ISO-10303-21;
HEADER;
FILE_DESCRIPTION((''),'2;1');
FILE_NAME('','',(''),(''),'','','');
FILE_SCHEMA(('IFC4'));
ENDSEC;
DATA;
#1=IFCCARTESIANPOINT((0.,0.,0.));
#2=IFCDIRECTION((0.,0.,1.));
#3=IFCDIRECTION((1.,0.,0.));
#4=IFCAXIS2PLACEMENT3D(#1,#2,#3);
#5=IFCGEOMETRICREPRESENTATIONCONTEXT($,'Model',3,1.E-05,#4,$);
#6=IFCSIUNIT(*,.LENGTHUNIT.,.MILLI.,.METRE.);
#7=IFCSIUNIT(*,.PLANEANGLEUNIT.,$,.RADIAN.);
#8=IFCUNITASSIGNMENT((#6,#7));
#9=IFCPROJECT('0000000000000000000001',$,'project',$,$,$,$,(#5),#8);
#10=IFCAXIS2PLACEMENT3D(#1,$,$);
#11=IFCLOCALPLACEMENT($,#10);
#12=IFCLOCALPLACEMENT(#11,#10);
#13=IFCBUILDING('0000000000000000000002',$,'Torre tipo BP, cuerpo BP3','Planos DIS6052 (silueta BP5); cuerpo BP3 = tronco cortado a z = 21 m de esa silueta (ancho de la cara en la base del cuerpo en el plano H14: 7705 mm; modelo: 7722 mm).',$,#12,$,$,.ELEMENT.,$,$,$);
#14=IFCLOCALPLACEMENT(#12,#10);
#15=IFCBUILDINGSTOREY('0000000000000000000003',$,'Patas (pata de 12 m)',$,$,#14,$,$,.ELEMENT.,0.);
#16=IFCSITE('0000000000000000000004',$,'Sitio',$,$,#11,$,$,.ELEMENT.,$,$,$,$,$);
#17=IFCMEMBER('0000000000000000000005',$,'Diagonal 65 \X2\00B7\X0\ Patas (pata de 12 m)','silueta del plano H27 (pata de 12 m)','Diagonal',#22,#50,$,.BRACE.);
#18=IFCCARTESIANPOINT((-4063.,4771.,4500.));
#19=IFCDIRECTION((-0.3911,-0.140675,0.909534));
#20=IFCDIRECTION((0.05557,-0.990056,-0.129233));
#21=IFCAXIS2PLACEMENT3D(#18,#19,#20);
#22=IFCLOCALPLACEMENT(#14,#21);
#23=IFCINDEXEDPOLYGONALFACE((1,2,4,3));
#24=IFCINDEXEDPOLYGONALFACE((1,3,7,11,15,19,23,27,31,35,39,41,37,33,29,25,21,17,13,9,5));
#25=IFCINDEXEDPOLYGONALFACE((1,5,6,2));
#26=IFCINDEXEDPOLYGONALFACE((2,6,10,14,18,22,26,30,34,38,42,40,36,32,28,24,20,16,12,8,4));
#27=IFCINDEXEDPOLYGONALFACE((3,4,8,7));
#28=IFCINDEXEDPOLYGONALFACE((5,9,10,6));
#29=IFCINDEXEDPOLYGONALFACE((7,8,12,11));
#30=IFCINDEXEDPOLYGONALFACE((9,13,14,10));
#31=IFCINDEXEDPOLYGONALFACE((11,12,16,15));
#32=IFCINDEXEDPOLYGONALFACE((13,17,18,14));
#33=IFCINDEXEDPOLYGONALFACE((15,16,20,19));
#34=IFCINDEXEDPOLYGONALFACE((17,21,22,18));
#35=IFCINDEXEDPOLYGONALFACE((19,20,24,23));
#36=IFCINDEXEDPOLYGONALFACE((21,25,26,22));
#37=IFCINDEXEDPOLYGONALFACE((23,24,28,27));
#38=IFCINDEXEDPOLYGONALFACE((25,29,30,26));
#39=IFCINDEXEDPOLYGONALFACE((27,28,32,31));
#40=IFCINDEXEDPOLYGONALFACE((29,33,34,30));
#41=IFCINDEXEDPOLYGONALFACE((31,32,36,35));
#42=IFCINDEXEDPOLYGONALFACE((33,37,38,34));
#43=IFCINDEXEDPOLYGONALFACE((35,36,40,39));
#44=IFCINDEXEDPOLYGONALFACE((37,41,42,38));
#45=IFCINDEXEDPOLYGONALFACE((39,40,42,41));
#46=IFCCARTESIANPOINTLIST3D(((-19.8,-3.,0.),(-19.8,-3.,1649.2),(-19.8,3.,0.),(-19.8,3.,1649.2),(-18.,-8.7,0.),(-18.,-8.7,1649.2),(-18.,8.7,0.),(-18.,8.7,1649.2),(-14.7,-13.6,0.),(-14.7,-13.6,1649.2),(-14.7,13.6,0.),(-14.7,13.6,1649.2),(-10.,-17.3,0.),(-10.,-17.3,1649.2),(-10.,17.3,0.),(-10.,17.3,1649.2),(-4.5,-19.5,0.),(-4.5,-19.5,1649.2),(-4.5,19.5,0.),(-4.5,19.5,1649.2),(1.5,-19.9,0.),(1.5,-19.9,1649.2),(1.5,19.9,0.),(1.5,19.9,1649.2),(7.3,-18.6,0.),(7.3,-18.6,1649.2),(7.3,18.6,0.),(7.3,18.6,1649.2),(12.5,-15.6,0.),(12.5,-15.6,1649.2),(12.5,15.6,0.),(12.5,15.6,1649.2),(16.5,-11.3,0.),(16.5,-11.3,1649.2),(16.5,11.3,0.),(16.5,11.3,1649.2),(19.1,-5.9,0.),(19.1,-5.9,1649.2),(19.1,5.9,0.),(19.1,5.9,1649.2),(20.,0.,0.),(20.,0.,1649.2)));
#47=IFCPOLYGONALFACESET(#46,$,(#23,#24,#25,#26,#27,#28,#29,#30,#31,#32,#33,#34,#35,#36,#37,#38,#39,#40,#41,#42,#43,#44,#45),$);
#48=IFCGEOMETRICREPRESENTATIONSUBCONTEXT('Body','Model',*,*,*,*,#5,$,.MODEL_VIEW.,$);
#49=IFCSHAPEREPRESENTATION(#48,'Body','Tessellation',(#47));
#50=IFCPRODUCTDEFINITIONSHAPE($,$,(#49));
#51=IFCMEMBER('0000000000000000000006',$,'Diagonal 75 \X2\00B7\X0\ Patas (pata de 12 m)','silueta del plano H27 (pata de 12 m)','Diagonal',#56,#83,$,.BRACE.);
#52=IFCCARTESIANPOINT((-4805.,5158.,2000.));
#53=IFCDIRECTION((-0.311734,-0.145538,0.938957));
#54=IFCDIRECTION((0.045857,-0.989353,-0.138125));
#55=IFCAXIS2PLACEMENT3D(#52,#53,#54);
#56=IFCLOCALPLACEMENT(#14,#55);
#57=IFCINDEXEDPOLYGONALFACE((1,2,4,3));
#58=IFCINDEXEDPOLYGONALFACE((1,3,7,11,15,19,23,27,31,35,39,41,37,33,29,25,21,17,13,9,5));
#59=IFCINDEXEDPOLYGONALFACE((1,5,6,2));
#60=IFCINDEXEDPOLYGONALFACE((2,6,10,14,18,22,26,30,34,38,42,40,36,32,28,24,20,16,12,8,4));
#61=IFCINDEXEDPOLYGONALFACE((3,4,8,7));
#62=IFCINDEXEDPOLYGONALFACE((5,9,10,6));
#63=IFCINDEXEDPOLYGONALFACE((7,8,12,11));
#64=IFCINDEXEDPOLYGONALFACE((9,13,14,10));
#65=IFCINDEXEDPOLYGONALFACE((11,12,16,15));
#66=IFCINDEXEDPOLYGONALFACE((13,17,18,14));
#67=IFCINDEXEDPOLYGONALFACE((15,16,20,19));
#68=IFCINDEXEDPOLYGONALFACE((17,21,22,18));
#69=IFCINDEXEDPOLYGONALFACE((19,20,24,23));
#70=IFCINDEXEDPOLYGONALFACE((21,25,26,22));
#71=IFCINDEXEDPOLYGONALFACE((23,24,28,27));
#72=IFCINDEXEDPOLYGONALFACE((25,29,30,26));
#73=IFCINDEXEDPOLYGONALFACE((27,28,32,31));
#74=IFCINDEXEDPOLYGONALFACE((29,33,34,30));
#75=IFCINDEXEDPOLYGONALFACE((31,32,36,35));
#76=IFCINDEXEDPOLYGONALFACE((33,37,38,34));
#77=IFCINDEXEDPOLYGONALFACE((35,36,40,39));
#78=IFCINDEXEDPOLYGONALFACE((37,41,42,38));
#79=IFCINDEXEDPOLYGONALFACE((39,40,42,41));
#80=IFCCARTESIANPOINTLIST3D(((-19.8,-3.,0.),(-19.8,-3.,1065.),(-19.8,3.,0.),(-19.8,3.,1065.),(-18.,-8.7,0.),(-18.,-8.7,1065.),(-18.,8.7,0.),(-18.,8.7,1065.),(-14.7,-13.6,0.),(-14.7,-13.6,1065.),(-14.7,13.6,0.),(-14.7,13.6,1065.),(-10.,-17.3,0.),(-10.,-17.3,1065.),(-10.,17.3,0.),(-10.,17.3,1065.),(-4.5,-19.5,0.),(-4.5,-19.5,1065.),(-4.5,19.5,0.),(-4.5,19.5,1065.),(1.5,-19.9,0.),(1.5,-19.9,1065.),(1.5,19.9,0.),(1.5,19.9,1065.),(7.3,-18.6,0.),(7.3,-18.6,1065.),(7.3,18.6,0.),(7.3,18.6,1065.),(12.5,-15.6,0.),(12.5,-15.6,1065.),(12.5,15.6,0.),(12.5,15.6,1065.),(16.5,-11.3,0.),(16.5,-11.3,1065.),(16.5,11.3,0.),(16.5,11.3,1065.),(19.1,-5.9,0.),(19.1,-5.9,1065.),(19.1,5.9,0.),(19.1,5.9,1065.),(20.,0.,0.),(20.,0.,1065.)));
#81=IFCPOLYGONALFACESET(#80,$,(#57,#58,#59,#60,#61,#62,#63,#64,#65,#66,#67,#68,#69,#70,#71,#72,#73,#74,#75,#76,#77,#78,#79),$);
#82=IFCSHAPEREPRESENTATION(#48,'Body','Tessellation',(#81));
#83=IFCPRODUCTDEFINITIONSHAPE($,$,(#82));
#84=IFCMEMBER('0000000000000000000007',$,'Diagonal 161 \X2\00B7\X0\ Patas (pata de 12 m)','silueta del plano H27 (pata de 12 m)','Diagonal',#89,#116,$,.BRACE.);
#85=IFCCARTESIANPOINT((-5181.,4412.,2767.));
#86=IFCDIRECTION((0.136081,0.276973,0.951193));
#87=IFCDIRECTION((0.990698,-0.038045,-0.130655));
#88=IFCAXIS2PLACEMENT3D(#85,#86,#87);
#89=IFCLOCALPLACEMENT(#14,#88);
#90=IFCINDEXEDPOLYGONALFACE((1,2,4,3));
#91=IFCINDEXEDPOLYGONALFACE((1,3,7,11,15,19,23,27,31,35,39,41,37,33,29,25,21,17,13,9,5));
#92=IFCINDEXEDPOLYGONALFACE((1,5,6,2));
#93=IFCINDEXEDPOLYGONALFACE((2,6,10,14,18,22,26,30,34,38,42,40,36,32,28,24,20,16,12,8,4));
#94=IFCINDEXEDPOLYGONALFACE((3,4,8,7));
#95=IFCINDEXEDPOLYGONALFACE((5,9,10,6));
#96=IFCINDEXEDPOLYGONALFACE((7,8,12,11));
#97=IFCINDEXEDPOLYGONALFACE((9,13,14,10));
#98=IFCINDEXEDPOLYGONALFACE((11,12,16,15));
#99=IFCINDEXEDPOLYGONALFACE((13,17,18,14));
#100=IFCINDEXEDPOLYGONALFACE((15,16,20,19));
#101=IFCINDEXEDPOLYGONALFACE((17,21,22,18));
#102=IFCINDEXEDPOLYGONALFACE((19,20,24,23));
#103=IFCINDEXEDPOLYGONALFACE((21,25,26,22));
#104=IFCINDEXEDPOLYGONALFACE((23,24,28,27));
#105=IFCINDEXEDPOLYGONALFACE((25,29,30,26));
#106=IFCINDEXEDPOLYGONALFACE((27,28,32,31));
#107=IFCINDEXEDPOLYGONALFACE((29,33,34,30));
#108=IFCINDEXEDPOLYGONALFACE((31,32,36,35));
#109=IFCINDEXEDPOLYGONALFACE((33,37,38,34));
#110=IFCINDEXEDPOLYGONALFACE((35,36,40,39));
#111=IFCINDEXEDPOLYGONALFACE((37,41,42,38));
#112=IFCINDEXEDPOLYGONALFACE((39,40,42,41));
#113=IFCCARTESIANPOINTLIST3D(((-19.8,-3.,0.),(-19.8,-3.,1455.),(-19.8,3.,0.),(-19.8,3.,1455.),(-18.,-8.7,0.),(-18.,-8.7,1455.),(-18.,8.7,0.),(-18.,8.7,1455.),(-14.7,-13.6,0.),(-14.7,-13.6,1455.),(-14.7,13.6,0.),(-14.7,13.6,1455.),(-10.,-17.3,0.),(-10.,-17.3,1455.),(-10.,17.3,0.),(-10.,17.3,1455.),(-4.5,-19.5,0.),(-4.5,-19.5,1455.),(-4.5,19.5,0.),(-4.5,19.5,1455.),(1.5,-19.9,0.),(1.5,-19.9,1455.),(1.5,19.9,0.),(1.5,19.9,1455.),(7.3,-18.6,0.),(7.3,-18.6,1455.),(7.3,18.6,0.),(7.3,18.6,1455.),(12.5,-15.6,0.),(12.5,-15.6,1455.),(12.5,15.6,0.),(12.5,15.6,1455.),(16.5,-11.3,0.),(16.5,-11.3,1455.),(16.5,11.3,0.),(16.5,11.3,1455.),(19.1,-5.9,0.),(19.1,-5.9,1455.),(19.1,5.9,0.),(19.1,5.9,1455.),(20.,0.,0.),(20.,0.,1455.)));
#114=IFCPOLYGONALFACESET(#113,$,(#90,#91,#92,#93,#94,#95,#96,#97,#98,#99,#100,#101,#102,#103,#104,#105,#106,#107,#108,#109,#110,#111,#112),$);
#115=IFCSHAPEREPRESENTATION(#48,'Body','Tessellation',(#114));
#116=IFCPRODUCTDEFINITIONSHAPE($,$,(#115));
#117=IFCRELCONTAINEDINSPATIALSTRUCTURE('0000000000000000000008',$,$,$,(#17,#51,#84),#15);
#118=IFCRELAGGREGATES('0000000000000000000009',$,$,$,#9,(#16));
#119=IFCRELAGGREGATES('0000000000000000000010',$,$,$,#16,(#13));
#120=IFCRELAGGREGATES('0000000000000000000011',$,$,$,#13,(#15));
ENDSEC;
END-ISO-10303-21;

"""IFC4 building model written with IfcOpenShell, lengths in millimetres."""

from ifc_helpers import new_model, si_unit, frame, origin, origin_with_axes, place, context, subcontext, project, spatial, circle, extrude, element, save


model = new_model("IFC4")

# Units and contexts
model_context = context("Model", 3, precision=1e-05, world=origin_with_axes())
body_context = subcontext(model_context, "Body", "Model", "MODEL_VIEW")
ifc_project = project(units=[si_unit("LENGTHUNIT", "METRE", prefix="MILLI"), si_unit("PLANEANGLEUNIT", "RADIAN")], contexts=[model_context])

# Site, building, storey
site_placement = place(None, origin())
site = spatial("IfcSite", under=ifc_project, at=site_placement, Name="Sitio", CompositionType="ELEMENT")
building_placement = place(site_placement, origin())
building = spatial("IfcBuilding", under=site, at=building_placement, Name="Torre tipo BP, cuerpo BP3", Description="Planos DIS6052 (silueta BP5); cuerpo BP3 = tronco cortado a z = 21 m de esa silueta (ancho de la cara en la base del cuerpo en el plano H14: 7705 mm; modelo: 7722 mm).", CompositionType="ELEMENT")
storey_placement = place(building_placement, origin())
storey = spatial("IfcBuildingStorey", under=building, at=storey_placement, Name="Patas (pata de 12 m)", CompositionType="ELEMENT", Elevation=0.0)

# Members
member_1_placement = place(storey_placement, frame((-4063.0, 4771.0, 4500.0), z_axis=(-0.3911, -0.140675, 0.909534), x_axis=(0.05557, -0.990056, -0.129233)))
element("IfcMember", 1, at=member_1_placement, inside=storey, Name="Diagonal 65 · Patas (pata de 12 m)", Description="silueta del plano H27 (pata de 12 m)", ObjectType="Diagonal", PredefinedType="BRACE", context=body_context, shape_type="SweptSolid", body=[
    extrude(circle(Radius=20.0), None, (0.0, 0.0, 1.0), 1649.2),
])
member_2_placement = place(storey_placement, frame((-4805.0, 5158.0, 2000.0), z_axis=(-0.311734, -0.145538, 0.938957), x_axis=(0.045857, -0.989353, -0.138125)))
element("IfcMember", 2, at=member_2_placement, inside=storey, Name="Diagonal 75 · Patas (pata de 12 m)", Description="silueta del plano H27 (pata de 12 m)", ObjectType="Diagonal", PredefinedType="BRACE", context=body_context, shape_type="SweptSolid", body=[
    extrude(circle(Radius=20.0), None, (0.0, 0.0, 1.0), 1065.0),
])
member_3_placement = place(storey_placement, frame((-5181.0, 4412.0, 2767.0), z_axis=(0.136081, 0.276973, 0.951193), x_axis=(0.990698, -0.038045, -0.130655)))
element("IfcMember", 3, at=member_3_placement, inside=storey, Name="Diagonal 161 · Patas (pata de 12 m)", Description="silueta del plano H27 (pata de 12 m)", ObjectType="Diagonal", PredefinedType="BRACE", context=body_context, shape_type="SweptSolid", body=[
    extrude(circle(Radius=20.0), None, (0.0, 0.0, 1.0), 1455.0),
])

save(model, "model.ifc")
